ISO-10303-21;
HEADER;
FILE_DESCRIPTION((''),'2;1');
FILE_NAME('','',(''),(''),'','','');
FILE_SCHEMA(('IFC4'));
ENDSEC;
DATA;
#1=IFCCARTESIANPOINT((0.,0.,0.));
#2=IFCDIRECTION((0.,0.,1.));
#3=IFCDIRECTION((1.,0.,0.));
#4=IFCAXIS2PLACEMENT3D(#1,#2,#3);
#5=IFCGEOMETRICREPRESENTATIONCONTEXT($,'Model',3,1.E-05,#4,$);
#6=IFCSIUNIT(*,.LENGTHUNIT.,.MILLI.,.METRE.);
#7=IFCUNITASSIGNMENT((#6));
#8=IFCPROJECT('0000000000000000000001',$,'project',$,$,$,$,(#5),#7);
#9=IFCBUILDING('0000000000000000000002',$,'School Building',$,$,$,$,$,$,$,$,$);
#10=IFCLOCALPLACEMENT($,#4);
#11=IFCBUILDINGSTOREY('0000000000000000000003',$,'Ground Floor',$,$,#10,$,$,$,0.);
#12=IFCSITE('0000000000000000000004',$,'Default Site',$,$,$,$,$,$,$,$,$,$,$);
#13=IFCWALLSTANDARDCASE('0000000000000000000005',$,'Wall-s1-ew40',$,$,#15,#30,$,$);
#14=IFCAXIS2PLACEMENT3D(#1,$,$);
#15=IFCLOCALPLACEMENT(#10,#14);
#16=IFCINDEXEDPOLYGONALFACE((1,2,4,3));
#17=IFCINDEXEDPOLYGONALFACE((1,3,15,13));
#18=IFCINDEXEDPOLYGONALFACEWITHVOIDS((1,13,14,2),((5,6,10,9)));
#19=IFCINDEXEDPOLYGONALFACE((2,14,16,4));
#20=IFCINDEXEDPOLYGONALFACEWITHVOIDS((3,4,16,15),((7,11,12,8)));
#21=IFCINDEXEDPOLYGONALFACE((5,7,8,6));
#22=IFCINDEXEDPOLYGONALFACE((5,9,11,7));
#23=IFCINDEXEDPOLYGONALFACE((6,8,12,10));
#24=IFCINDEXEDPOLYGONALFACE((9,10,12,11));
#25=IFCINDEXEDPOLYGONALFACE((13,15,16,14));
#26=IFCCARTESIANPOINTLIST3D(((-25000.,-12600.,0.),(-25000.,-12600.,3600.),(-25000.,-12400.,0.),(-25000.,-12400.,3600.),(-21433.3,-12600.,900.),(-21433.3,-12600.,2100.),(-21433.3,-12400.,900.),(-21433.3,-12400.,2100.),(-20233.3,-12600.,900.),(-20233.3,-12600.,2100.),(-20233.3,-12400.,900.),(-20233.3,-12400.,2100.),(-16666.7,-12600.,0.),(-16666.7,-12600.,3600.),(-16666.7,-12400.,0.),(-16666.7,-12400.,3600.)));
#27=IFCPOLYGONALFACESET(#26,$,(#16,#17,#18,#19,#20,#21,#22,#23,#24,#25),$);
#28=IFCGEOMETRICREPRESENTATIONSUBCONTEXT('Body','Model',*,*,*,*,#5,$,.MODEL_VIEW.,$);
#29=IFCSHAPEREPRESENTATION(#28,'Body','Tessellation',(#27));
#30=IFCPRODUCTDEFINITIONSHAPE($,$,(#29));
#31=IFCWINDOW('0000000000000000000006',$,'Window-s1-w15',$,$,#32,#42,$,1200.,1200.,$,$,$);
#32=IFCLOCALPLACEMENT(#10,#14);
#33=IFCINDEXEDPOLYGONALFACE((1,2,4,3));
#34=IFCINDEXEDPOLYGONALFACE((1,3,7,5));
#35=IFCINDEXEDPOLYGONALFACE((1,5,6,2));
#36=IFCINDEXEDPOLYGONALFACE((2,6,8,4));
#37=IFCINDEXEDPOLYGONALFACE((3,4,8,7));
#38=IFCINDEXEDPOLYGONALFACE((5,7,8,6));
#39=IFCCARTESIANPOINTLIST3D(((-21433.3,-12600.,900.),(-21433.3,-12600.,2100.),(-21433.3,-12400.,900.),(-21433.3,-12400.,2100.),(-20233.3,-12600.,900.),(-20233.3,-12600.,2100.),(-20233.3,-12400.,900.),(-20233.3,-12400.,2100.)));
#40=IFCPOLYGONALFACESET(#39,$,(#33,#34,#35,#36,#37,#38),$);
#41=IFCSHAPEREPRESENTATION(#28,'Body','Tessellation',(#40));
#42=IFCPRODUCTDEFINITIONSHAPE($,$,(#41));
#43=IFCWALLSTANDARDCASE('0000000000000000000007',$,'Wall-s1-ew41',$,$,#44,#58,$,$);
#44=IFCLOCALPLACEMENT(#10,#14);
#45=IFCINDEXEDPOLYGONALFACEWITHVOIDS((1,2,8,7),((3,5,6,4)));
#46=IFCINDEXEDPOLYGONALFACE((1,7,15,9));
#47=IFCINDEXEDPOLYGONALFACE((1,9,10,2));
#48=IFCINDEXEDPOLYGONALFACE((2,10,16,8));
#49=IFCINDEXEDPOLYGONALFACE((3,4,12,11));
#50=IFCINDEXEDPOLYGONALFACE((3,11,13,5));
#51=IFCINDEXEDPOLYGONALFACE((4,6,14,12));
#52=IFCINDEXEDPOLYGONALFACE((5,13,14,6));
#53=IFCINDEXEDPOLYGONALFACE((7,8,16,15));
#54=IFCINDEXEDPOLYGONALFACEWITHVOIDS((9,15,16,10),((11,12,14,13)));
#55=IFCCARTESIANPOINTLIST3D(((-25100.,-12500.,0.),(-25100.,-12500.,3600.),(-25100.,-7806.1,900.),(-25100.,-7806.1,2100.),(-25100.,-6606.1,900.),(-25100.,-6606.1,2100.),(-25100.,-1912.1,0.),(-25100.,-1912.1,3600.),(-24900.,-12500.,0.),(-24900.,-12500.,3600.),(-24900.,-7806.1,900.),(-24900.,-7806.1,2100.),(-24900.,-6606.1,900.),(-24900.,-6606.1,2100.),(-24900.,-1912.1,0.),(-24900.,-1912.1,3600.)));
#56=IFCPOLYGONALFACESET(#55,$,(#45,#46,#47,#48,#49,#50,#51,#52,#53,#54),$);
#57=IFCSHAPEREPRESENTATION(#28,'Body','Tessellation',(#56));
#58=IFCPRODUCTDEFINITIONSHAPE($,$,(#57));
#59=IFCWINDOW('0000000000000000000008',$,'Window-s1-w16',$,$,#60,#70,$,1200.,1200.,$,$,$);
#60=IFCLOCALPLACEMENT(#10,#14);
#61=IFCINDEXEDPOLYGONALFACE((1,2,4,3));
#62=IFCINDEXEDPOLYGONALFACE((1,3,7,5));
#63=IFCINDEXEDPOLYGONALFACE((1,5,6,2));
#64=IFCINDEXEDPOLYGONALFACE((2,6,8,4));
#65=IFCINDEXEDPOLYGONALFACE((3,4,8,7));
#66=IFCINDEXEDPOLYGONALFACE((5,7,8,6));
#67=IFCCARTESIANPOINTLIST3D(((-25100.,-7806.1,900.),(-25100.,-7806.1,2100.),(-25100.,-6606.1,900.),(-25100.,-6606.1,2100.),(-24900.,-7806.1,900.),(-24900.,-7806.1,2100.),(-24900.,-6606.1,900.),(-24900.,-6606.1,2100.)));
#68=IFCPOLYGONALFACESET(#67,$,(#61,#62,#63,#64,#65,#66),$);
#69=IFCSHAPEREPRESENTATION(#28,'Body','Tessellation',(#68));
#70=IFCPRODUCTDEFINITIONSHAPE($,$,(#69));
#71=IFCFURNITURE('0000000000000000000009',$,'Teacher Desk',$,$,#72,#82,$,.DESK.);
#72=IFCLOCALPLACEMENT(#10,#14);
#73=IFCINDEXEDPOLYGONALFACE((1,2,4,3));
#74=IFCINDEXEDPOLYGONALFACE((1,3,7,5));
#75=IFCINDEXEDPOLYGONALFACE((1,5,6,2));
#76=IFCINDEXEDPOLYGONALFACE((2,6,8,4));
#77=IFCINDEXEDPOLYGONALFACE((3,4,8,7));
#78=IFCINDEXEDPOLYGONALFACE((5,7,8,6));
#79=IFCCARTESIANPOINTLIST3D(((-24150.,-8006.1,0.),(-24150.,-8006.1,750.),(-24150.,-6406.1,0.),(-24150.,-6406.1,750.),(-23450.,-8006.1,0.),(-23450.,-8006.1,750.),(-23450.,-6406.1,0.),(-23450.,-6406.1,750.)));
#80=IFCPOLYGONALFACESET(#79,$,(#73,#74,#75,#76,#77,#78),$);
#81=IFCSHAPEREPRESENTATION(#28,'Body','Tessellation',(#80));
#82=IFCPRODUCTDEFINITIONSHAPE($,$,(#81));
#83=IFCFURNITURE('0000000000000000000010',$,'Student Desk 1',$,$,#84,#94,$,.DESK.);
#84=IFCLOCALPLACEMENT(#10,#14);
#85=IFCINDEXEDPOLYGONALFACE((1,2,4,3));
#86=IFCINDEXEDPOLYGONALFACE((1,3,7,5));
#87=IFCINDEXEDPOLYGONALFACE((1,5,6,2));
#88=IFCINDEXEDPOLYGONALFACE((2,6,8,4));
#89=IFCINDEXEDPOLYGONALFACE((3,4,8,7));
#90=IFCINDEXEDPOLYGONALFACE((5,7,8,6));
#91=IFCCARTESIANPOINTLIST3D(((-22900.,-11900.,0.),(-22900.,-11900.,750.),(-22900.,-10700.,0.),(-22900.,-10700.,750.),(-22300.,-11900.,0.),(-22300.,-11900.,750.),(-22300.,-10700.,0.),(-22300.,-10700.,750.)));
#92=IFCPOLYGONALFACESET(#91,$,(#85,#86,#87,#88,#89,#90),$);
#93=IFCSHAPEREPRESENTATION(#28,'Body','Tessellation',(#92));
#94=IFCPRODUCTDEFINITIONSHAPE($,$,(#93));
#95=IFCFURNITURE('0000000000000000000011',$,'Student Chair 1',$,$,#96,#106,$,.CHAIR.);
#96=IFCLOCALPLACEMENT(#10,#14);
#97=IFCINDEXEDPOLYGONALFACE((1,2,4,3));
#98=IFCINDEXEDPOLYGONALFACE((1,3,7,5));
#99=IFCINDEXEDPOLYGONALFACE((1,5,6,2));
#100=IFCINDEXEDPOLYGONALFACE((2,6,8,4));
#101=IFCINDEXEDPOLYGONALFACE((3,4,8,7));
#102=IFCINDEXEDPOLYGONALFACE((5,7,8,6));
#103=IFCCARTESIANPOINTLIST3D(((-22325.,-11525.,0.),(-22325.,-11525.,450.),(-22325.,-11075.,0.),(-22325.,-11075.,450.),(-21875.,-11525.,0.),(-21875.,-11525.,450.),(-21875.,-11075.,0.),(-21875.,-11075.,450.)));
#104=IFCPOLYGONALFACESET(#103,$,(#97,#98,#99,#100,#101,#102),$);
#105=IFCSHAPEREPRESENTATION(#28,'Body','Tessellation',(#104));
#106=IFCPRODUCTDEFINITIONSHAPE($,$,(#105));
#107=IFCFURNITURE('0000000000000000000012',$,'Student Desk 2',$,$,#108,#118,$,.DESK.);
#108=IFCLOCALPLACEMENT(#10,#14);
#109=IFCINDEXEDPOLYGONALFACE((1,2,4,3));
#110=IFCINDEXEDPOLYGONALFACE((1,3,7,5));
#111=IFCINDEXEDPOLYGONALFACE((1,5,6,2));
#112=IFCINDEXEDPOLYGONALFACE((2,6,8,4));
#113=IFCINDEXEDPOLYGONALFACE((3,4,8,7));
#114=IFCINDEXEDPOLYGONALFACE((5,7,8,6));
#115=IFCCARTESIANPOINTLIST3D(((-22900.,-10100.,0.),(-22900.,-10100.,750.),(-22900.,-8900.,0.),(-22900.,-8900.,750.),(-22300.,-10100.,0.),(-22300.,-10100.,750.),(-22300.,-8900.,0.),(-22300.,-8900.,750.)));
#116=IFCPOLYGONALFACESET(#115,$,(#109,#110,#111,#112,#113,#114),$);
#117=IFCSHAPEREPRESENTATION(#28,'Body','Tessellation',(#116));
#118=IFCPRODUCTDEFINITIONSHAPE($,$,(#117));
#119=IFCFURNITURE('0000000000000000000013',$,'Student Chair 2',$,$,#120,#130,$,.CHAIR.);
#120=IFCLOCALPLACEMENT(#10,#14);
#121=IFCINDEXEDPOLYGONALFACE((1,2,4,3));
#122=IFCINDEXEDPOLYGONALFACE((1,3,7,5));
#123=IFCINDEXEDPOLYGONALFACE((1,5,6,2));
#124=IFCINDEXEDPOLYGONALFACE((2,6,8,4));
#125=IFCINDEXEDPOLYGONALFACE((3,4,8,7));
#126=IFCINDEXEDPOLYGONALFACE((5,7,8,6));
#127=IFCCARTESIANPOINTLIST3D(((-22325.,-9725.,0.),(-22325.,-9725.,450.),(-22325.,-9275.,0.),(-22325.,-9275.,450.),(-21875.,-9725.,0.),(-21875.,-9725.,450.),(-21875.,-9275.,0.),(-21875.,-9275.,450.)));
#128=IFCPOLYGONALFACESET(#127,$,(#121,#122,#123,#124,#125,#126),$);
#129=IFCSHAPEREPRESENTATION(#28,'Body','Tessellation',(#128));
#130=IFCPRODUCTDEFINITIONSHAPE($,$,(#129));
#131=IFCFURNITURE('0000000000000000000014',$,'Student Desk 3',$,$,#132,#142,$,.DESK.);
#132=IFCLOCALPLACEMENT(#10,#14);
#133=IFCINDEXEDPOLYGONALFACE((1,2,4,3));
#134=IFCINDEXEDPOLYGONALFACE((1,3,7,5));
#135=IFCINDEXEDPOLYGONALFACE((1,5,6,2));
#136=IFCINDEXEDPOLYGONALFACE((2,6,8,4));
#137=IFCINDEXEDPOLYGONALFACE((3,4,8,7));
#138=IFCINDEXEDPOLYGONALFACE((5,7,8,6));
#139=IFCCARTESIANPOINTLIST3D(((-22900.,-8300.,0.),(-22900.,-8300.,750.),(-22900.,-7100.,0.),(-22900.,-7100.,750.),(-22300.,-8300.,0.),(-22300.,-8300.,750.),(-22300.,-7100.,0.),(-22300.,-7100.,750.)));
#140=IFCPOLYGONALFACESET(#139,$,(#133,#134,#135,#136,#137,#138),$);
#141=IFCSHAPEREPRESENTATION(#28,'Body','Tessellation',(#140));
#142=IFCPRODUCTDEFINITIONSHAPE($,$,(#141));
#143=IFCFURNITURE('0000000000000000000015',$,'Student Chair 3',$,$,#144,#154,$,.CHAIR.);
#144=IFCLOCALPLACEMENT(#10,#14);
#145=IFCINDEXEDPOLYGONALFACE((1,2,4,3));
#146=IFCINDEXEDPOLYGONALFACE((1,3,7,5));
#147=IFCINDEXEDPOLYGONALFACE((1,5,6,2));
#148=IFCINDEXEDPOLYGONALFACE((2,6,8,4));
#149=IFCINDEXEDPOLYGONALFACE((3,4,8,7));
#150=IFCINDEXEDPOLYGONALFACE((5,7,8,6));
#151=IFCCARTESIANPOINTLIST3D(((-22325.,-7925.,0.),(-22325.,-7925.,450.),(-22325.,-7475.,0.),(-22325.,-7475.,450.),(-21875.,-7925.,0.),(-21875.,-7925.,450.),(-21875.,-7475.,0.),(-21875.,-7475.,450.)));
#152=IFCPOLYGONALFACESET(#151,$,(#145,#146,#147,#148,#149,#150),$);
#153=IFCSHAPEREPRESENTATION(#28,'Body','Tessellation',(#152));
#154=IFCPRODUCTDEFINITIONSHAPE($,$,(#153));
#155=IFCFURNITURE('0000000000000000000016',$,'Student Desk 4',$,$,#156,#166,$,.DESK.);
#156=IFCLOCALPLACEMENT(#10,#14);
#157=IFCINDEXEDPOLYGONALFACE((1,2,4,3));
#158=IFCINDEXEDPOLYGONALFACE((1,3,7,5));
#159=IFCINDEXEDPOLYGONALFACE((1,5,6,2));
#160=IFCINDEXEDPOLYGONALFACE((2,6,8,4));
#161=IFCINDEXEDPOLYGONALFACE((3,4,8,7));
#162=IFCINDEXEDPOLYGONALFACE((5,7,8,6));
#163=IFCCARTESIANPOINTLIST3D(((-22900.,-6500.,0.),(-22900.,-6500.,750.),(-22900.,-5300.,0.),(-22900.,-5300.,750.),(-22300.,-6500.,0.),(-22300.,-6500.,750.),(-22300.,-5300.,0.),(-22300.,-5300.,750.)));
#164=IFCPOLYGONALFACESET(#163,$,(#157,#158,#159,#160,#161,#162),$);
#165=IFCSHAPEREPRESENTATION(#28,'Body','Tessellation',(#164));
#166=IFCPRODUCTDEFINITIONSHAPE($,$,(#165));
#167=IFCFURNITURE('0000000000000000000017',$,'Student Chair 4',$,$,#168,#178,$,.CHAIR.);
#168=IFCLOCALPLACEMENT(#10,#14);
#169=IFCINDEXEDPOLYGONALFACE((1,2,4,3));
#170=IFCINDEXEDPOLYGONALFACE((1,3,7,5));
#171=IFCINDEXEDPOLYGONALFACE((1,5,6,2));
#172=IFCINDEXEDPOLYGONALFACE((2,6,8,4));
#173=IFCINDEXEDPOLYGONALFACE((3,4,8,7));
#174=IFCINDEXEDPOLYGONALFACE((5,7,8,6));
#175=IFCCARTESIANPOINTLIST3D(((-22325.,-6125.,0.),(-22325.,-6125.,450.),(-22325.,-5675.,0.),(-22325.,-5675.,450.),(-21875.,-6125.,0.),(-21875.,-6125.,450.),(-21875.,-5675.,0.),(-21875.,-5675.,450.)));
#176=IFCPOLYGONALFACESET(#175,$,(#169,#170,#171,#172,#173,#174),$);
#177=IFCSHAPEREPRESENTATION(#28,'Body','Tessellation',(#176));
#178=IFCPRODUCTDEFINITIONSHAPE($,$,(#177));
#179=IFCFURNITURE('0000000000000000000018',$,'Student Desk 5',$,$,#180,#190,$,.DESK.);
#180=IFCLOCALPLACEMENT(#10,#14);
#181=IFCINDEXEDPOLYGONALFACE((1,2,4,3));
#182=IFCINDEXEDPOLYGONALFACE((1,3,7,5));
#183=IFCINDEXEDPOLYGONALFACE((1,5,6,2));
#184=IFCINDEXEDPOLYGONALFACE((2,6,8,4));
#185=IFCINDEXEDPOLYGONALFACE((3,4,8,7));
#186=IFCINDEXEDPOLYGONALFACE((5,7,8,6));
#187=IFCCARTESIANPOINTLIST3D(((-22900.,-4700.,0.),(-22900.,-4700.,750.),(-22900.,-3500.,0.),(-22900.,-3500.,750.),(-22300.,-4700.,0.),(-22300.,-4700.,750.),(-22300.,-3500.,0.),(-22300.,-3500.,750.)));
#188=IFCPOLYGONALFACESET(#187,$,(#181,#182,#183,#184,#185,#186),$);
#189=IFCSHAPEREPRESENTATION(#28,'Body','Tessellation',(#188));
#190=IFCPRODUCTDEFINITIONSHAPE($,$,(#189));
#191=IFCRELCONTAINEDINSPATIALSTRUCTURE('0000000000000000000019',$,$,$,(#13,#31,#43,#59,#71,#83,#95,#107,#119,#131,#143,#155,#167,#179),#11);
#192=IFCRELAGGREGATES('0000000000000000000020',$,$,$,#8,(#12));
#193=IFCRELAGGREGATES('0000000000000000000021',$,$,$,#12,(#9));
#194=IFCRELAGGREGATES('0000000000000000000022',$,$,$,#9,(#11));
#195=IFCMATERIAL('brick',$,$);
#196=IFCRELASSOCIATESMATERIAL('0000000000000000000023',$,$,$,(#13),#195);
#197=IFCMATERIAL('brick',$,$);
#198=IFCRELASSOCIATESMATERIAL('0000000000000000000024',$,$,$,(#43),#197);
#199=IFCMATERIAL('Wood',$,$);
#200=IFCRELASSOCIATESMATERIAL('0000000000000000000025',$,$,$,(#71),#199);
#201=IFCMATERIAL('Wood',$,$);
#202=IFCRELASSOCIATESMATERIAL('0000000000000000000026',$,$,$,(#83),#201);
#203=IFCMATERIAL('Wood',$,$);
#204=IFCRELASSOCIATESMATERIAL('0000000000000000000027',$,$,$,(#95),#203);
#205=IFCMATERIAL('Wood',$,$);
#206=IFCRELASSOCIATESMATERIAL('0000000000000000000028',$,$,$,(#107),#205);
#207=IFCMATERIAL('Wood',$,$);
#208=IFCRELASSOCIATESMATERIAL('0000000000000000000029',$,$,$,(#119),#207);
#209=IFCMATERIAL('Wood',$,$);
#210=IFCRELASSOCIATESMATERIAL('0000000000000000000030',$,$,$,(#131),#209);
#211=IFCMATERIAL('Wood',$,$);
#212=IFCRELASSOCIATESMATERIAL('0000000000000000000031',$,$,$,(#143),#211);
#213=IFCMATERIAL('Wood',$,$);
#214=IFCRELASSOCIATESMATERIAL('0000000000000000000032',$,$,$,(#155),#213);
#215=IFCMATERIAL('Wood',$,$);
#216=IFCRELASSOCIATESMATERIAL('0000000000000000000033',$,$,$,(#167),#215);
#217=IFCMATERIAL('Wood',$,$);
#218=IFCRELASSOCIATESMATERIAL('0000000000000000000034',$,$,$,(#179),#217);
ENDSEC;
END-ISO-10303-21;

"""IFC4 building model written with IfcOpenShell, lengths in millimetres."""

from ifc_helpers import new_model, si_unit, frame, frame_2d, origin_with_axes, origin_2d, place, context, subcontext, project, spatial, rectangle, extrude, material, element, fill, save


model = new_model("IFC4")

# Units and contexts
model_context = context("Model", 3, precision=1e-05, world=origin_with_axes())
body_context = subcontext(model_context, "Body", "Model", "MODEL_VIEW")
ifc_project = project(units=[si_unit("LENGTHUNIT", "METRE", prefix="MILLI")], contexts=[model_context])

# Site, building, storey
site = spatial("IfcSite", under=ifc_project, Name="Default Site")
building = spatial("IfcBuilding", under=site, Name="School Building")
storey_placement = place(None, origin_with_axes())
storey = spatial("IfcBuildingStorey", under=building, at=storey_placement, Name="Ground Floor", Elevation=0.0)

# Walls, openings, windows
ifc_material_1 = material(Name="brick")
wall_1_placement = place(storey_placement, frame((-25000.0, -12500.0, 0.0), z_axis=(0.0, 0.0, 1.0), x_axis=(1.0, 0.0, 0.0)))
wall_1 = element("IfcWallStandardCase", 1, at=wall_1_placement, inside=storey, material=ifc_material_1, Name="Wall-s1-ew40", context=body_context, shape_type="SweptSolid", body=[
    extrude(rectangle(XDim=8333.3, YDim=200.0, at=frame_2d((4166.7, 0.0))), origin_with_axes(), (0.0, 0.0, 1.0), 3600.0),
])
opening_1_placement = place(wall_1_placement, frame((3566.7, 0.0, 900.0), z_axis=(0.0, 0.0, 1.0), x_axis=(1.0, 0.0, 0.0)))
opening_1 = element("IfcOpeningElement", 2, at=opening_1_placement, cuts=wall_1, context=body_context, shape_type="SweptSolid", body=[
    extrude(rectangle(XDim=1200.0, YDim=400.0, at=frame_2d((600.0, 0.0))), origin_with_axes(), (0.0, 0.0, 1.0), 1200.0),
])
window_1_placement = place(storey_placement, frame((-21433.3, -12500.0, 900.0), z_axis=(0.0, 0.0, 1.0), x_axis=(1.0, 0.0, 0.0)))
window_1 = element("IfcWindow", 3, at=window_1_placement, inside=storey, Name="Window-s1-w15", OverallHeight=1200.0, OverallWidth=1200.0, context=body_context, shape_type="SweptSolid", body=[
    extrude(rectangle(XDim=1200.0, YDim=200.0, at=frame_2d((600.0, 0.0))), origin_with_axes(), (0.0, 0.0, 1.0), 1200.0),
])
fill(opening_1, window_1)
ifc_material_2 = material(Name="brick")
wall_2_placement = place(storey_placement, frame((-25000.0, -12500.0, 0.0), z_axis=(0.0, 0.0, 1.0), x_axis=(0.0, 1.0, 0.0)))
wall_2 = element("IfcWallStandardCase", 4, at=wall_2_placement, inside=storey, material=ifc_material_2, Name="Wall-s1-ew41", context=body_context, shape_type="SweptSolid", body=[
    extrude(rectangle(XDim=10587.9, YDim=200.0, at=frame_2d((5293.9, 0.0))), origin_with_axes(), (0.0, 0.0, 1.0), 3600.0),
])
opening_2_placement = place(wall_2_placement, frame((4693.9, 0.0, 900.0), z_axis=(0.0, 0.0, 1.0), x_axis=(1.0, 0.0, 0.0)))
opening_2 = element("IfcOpeningElement", 5, at=opening_2_placement, cuts=wall_2, context=body_context, shape_type="SweptSolid", body=[
    extrude(rectangle(XDim=1200.0, YDim=400.0, at=frame_2d((600.0, 0.0))), origin_with_axes(), (0.0, 0.0, 1.0), 1200.0),
])
window_2_placement = place(storey_placement, frame((-25000.0, -7806.1, 900.0), z_axis=(0.0, 0.0, 1.0), x_axis=(0.0, 1.0, 0.0)))
window_2 = element("IfcWindow", 6, at=window_2_placement, inside=storey, Name="Window-s1-w16", OverallHeight=1200.0, OverallWidth=1200.0, context=body_context, shape_type="SweptSolid", body=[
    extrude(rectangle(XDim=1200.0, YDim=200.0, at=frame_2d((600.0, 0.0))), origin_with_axes(), (0.0, 0.0, 1.0), 1200.0),
])
fill(opening_2, window_2)

# Furniture
ifc_material_3 = material(Name="Wood")
furniture_1_placement = place(storey_placement, frame((-23800.0, -7206.1, 0.0), z_axis=(0.0, 0.0, 1.0), x_axis=(0.0, 1.0, 0.0)))
element("IfcFurniture", 7, at=furniture_1_placement, inside=storey, material=ifc_material_3, Name="Teacher Desk", PredefinedType="DESK", context=body_context, shape_type="SweptSolid", body=[
    extrude(rectangle(XDim=1600.0, YDim=700.0, at=origin_2d()), origin_with_axes(), (0.0, 0.0, 1.0), 750.0),
])
ifc_material_4 = material(Name="Wood")
furniture_2_placement = place(storey_placement, frame((-22600.0, -11300.0, 0.0), z_axis=(0.0, 0.0, 1.0), x_axis=(0.0, 1.0, 0.0)))
element("IfcFurniture", 8, at=furniture_2_placement, inside=storey, material=ifc_material_4, Name="Student Desk 1", PredefinedType="DESK", context=body_context, shape_type="SweptSolid", body=[
    extrude(rectangle(XDim=1200.0, YDim=600.0, at=origin_2d()), origin_with_axes(), (0.0, 0.0, 1.0), 750.0),
])
ifc_material_5 = material(Name="Wood")
furniture_3_placement = place(storey_placement, frame((-22100.0, -11300.0, 0.0), z_axis=(0.0, 0.0, 1.0), x_axis=(1.0, 0.0, 0.0)))
element("IfcFurniture", 9, at=furniture_3_placement, inside=storey, material=ifc_material_5, Name="Student Chair 1", PredefinedType="CHAIR", context=body_context, shape_type="SweptSolid", body=[
    extrude(rectangle(XDim=450.0, YDim=450.0, at=origin_2d()), origin_with_axes(), (0.0, 0.0, 1.0), 450.0),
])
ifc_material_6 = material(Name="Wood")
furniture_4_placement = place(storey_placement, frame((-22600.0, -9500.0, 0.0), z_axis=(0.0, 0.0, 1.0), x_axis=(0.0, 1.0, 0.0)))
element("IfcFurniture", 10, at=furniture_4_placement, inside=storey, material=ifc_material_6, Name="Student Desk 2", PredefinedType="DESK", context=body_context, shape_type="SweptSolid", body=[
    extrude(rectangle(XDim=1200.0, YDim=600.0, at=origin_2d()), origin_with_axes(), (0.0, 0.0, 1.0), 750.0),
])
ifc_material_7 = material(Name="Wood")
furniture_5_placement = place(storey_placement, frame((-22100.0, -9500.0, 0.0), z_axis=(0.0, 0.0, 1.0), x_axis=(1.0, 0.0, 0.0)))
element("IfcFurniture", 11, at=furniture_5_placement, inside=storey, material=ifc_material_7, Name="Student Chair 2", PredefinedType="CHAIR", context=body_context, shape_type="SweptSolid", body=[
    extrude(rectangle(XDim=450.0, YDim=450.0, at=origin_2d()), origin_with_axes(), (0.0, 0.0, 1.0), 450.0),
])
ifc_material_8 = material(Name="Wood")
furniture_6_placement = place(storey_placement, frame((-22600.0, -7700.0, 0.0), z_axis=(0.0, 0.0, 1.0), x_axis=(0.0, 1.0, 0.0)))
element("IfcFurniture", 12, at=furniture_6_placement, inside=storey, material=ifc_material_8, Name="Student Desk 3", PredefinedType="DESK", context=body_context, shape_type="SweptSolid", body=[
    extrude(rectangle(XDim=1200.0, YDim=600.0, at=origin_2d()), origin_with_axes(), (0.0, 0.0, 1.0), 750.0),
])
ifc_material_9 = material(Name="Wood")
furniture_7_placement = place(storey_placement, frame((-22100.0, -7700.0, 0.0), z_axis=(0.0, 0.0, 1.0), x_axis=(1.0, 0.0, 0.0)))
element("IfcFurniture", 13, at=furniture_7_placement, inside=storey, material=ifc_material_9, Name="Student Chair 3", PredefinedType="CHAIR", context=body_context, shape_type="SweptSolid", body=[
    extrude(rectangle(XDim=450.0, YDim=450.0, at=origin_2d()), origin_with_axes(), (0.0, 0.0, 1.0), 450.0),
])
ifc_material_10 = material(Name="Wood")
furniture_8_placement = place(storey_placement, frame((-22600.0, -5900.0, 0.0), z_axis=(0.0, 0.0, 1.0), x_axis=(0.0, 1.0, 0.0)))
element("IfcFurniture", 14, at=furniture_8_placement, inside=storey, material=ifc_material_10, Name="Student Desk 4", PredefinedType="DESK", context=body_context, shape_type="SweptSolid", body=[
    extrude(rectangle(XDim=1200.0, YDim=600.0, at=origin_2d()), origin_with_axes(), (0.0, 0.0, 1.0), 750.0),
])
ifc_material_11 = material(Name="Wood")
furniture_9_placement = place(storey_placement, frame((-22100.0, -5900.0, 0.0), z_axis=(0.0, 0.0, 1.0), x_axis=(1.0, 0.0, 0.0)))
element("IfcFurniture", 15, at=furniture_9_placement, inside=storey, material=ifc_material_11, Name="Student Chair 4", PredefinedType="CHAIR", context=body_context, shape_type="SweptSolid", body=[
    extrude(rectangle(XDim=450.0, YDim=450.0, at=origin_2d()), origin_with_axes(), (0.0, 0.0, 1.0), 450.0),
])
ifc_material_12 = material(Name="Wood")
furniture_10_placement = place(storey_placement, frame((-22600.0, -4100.0, 0.0), z_axis=(0.0, 0.0, 1.0), x_axis=(0.0, 1.0, 0.0)))
element("IfcFurniture", 16, at=furniture_10_placement, inside=storey, material=ifc_material_12, Name="Student Desk 5", PredefinedType="DESK", context=body_context, shape_type="SweptSolid", body=[
    extrude(rectangle(XDim=1200.0, YDim=600.0, at=origin_2d()), origin_with_axes(), (0.0, 0.0, 1.0), 750.0),
])

save(model, "model.ifc")
